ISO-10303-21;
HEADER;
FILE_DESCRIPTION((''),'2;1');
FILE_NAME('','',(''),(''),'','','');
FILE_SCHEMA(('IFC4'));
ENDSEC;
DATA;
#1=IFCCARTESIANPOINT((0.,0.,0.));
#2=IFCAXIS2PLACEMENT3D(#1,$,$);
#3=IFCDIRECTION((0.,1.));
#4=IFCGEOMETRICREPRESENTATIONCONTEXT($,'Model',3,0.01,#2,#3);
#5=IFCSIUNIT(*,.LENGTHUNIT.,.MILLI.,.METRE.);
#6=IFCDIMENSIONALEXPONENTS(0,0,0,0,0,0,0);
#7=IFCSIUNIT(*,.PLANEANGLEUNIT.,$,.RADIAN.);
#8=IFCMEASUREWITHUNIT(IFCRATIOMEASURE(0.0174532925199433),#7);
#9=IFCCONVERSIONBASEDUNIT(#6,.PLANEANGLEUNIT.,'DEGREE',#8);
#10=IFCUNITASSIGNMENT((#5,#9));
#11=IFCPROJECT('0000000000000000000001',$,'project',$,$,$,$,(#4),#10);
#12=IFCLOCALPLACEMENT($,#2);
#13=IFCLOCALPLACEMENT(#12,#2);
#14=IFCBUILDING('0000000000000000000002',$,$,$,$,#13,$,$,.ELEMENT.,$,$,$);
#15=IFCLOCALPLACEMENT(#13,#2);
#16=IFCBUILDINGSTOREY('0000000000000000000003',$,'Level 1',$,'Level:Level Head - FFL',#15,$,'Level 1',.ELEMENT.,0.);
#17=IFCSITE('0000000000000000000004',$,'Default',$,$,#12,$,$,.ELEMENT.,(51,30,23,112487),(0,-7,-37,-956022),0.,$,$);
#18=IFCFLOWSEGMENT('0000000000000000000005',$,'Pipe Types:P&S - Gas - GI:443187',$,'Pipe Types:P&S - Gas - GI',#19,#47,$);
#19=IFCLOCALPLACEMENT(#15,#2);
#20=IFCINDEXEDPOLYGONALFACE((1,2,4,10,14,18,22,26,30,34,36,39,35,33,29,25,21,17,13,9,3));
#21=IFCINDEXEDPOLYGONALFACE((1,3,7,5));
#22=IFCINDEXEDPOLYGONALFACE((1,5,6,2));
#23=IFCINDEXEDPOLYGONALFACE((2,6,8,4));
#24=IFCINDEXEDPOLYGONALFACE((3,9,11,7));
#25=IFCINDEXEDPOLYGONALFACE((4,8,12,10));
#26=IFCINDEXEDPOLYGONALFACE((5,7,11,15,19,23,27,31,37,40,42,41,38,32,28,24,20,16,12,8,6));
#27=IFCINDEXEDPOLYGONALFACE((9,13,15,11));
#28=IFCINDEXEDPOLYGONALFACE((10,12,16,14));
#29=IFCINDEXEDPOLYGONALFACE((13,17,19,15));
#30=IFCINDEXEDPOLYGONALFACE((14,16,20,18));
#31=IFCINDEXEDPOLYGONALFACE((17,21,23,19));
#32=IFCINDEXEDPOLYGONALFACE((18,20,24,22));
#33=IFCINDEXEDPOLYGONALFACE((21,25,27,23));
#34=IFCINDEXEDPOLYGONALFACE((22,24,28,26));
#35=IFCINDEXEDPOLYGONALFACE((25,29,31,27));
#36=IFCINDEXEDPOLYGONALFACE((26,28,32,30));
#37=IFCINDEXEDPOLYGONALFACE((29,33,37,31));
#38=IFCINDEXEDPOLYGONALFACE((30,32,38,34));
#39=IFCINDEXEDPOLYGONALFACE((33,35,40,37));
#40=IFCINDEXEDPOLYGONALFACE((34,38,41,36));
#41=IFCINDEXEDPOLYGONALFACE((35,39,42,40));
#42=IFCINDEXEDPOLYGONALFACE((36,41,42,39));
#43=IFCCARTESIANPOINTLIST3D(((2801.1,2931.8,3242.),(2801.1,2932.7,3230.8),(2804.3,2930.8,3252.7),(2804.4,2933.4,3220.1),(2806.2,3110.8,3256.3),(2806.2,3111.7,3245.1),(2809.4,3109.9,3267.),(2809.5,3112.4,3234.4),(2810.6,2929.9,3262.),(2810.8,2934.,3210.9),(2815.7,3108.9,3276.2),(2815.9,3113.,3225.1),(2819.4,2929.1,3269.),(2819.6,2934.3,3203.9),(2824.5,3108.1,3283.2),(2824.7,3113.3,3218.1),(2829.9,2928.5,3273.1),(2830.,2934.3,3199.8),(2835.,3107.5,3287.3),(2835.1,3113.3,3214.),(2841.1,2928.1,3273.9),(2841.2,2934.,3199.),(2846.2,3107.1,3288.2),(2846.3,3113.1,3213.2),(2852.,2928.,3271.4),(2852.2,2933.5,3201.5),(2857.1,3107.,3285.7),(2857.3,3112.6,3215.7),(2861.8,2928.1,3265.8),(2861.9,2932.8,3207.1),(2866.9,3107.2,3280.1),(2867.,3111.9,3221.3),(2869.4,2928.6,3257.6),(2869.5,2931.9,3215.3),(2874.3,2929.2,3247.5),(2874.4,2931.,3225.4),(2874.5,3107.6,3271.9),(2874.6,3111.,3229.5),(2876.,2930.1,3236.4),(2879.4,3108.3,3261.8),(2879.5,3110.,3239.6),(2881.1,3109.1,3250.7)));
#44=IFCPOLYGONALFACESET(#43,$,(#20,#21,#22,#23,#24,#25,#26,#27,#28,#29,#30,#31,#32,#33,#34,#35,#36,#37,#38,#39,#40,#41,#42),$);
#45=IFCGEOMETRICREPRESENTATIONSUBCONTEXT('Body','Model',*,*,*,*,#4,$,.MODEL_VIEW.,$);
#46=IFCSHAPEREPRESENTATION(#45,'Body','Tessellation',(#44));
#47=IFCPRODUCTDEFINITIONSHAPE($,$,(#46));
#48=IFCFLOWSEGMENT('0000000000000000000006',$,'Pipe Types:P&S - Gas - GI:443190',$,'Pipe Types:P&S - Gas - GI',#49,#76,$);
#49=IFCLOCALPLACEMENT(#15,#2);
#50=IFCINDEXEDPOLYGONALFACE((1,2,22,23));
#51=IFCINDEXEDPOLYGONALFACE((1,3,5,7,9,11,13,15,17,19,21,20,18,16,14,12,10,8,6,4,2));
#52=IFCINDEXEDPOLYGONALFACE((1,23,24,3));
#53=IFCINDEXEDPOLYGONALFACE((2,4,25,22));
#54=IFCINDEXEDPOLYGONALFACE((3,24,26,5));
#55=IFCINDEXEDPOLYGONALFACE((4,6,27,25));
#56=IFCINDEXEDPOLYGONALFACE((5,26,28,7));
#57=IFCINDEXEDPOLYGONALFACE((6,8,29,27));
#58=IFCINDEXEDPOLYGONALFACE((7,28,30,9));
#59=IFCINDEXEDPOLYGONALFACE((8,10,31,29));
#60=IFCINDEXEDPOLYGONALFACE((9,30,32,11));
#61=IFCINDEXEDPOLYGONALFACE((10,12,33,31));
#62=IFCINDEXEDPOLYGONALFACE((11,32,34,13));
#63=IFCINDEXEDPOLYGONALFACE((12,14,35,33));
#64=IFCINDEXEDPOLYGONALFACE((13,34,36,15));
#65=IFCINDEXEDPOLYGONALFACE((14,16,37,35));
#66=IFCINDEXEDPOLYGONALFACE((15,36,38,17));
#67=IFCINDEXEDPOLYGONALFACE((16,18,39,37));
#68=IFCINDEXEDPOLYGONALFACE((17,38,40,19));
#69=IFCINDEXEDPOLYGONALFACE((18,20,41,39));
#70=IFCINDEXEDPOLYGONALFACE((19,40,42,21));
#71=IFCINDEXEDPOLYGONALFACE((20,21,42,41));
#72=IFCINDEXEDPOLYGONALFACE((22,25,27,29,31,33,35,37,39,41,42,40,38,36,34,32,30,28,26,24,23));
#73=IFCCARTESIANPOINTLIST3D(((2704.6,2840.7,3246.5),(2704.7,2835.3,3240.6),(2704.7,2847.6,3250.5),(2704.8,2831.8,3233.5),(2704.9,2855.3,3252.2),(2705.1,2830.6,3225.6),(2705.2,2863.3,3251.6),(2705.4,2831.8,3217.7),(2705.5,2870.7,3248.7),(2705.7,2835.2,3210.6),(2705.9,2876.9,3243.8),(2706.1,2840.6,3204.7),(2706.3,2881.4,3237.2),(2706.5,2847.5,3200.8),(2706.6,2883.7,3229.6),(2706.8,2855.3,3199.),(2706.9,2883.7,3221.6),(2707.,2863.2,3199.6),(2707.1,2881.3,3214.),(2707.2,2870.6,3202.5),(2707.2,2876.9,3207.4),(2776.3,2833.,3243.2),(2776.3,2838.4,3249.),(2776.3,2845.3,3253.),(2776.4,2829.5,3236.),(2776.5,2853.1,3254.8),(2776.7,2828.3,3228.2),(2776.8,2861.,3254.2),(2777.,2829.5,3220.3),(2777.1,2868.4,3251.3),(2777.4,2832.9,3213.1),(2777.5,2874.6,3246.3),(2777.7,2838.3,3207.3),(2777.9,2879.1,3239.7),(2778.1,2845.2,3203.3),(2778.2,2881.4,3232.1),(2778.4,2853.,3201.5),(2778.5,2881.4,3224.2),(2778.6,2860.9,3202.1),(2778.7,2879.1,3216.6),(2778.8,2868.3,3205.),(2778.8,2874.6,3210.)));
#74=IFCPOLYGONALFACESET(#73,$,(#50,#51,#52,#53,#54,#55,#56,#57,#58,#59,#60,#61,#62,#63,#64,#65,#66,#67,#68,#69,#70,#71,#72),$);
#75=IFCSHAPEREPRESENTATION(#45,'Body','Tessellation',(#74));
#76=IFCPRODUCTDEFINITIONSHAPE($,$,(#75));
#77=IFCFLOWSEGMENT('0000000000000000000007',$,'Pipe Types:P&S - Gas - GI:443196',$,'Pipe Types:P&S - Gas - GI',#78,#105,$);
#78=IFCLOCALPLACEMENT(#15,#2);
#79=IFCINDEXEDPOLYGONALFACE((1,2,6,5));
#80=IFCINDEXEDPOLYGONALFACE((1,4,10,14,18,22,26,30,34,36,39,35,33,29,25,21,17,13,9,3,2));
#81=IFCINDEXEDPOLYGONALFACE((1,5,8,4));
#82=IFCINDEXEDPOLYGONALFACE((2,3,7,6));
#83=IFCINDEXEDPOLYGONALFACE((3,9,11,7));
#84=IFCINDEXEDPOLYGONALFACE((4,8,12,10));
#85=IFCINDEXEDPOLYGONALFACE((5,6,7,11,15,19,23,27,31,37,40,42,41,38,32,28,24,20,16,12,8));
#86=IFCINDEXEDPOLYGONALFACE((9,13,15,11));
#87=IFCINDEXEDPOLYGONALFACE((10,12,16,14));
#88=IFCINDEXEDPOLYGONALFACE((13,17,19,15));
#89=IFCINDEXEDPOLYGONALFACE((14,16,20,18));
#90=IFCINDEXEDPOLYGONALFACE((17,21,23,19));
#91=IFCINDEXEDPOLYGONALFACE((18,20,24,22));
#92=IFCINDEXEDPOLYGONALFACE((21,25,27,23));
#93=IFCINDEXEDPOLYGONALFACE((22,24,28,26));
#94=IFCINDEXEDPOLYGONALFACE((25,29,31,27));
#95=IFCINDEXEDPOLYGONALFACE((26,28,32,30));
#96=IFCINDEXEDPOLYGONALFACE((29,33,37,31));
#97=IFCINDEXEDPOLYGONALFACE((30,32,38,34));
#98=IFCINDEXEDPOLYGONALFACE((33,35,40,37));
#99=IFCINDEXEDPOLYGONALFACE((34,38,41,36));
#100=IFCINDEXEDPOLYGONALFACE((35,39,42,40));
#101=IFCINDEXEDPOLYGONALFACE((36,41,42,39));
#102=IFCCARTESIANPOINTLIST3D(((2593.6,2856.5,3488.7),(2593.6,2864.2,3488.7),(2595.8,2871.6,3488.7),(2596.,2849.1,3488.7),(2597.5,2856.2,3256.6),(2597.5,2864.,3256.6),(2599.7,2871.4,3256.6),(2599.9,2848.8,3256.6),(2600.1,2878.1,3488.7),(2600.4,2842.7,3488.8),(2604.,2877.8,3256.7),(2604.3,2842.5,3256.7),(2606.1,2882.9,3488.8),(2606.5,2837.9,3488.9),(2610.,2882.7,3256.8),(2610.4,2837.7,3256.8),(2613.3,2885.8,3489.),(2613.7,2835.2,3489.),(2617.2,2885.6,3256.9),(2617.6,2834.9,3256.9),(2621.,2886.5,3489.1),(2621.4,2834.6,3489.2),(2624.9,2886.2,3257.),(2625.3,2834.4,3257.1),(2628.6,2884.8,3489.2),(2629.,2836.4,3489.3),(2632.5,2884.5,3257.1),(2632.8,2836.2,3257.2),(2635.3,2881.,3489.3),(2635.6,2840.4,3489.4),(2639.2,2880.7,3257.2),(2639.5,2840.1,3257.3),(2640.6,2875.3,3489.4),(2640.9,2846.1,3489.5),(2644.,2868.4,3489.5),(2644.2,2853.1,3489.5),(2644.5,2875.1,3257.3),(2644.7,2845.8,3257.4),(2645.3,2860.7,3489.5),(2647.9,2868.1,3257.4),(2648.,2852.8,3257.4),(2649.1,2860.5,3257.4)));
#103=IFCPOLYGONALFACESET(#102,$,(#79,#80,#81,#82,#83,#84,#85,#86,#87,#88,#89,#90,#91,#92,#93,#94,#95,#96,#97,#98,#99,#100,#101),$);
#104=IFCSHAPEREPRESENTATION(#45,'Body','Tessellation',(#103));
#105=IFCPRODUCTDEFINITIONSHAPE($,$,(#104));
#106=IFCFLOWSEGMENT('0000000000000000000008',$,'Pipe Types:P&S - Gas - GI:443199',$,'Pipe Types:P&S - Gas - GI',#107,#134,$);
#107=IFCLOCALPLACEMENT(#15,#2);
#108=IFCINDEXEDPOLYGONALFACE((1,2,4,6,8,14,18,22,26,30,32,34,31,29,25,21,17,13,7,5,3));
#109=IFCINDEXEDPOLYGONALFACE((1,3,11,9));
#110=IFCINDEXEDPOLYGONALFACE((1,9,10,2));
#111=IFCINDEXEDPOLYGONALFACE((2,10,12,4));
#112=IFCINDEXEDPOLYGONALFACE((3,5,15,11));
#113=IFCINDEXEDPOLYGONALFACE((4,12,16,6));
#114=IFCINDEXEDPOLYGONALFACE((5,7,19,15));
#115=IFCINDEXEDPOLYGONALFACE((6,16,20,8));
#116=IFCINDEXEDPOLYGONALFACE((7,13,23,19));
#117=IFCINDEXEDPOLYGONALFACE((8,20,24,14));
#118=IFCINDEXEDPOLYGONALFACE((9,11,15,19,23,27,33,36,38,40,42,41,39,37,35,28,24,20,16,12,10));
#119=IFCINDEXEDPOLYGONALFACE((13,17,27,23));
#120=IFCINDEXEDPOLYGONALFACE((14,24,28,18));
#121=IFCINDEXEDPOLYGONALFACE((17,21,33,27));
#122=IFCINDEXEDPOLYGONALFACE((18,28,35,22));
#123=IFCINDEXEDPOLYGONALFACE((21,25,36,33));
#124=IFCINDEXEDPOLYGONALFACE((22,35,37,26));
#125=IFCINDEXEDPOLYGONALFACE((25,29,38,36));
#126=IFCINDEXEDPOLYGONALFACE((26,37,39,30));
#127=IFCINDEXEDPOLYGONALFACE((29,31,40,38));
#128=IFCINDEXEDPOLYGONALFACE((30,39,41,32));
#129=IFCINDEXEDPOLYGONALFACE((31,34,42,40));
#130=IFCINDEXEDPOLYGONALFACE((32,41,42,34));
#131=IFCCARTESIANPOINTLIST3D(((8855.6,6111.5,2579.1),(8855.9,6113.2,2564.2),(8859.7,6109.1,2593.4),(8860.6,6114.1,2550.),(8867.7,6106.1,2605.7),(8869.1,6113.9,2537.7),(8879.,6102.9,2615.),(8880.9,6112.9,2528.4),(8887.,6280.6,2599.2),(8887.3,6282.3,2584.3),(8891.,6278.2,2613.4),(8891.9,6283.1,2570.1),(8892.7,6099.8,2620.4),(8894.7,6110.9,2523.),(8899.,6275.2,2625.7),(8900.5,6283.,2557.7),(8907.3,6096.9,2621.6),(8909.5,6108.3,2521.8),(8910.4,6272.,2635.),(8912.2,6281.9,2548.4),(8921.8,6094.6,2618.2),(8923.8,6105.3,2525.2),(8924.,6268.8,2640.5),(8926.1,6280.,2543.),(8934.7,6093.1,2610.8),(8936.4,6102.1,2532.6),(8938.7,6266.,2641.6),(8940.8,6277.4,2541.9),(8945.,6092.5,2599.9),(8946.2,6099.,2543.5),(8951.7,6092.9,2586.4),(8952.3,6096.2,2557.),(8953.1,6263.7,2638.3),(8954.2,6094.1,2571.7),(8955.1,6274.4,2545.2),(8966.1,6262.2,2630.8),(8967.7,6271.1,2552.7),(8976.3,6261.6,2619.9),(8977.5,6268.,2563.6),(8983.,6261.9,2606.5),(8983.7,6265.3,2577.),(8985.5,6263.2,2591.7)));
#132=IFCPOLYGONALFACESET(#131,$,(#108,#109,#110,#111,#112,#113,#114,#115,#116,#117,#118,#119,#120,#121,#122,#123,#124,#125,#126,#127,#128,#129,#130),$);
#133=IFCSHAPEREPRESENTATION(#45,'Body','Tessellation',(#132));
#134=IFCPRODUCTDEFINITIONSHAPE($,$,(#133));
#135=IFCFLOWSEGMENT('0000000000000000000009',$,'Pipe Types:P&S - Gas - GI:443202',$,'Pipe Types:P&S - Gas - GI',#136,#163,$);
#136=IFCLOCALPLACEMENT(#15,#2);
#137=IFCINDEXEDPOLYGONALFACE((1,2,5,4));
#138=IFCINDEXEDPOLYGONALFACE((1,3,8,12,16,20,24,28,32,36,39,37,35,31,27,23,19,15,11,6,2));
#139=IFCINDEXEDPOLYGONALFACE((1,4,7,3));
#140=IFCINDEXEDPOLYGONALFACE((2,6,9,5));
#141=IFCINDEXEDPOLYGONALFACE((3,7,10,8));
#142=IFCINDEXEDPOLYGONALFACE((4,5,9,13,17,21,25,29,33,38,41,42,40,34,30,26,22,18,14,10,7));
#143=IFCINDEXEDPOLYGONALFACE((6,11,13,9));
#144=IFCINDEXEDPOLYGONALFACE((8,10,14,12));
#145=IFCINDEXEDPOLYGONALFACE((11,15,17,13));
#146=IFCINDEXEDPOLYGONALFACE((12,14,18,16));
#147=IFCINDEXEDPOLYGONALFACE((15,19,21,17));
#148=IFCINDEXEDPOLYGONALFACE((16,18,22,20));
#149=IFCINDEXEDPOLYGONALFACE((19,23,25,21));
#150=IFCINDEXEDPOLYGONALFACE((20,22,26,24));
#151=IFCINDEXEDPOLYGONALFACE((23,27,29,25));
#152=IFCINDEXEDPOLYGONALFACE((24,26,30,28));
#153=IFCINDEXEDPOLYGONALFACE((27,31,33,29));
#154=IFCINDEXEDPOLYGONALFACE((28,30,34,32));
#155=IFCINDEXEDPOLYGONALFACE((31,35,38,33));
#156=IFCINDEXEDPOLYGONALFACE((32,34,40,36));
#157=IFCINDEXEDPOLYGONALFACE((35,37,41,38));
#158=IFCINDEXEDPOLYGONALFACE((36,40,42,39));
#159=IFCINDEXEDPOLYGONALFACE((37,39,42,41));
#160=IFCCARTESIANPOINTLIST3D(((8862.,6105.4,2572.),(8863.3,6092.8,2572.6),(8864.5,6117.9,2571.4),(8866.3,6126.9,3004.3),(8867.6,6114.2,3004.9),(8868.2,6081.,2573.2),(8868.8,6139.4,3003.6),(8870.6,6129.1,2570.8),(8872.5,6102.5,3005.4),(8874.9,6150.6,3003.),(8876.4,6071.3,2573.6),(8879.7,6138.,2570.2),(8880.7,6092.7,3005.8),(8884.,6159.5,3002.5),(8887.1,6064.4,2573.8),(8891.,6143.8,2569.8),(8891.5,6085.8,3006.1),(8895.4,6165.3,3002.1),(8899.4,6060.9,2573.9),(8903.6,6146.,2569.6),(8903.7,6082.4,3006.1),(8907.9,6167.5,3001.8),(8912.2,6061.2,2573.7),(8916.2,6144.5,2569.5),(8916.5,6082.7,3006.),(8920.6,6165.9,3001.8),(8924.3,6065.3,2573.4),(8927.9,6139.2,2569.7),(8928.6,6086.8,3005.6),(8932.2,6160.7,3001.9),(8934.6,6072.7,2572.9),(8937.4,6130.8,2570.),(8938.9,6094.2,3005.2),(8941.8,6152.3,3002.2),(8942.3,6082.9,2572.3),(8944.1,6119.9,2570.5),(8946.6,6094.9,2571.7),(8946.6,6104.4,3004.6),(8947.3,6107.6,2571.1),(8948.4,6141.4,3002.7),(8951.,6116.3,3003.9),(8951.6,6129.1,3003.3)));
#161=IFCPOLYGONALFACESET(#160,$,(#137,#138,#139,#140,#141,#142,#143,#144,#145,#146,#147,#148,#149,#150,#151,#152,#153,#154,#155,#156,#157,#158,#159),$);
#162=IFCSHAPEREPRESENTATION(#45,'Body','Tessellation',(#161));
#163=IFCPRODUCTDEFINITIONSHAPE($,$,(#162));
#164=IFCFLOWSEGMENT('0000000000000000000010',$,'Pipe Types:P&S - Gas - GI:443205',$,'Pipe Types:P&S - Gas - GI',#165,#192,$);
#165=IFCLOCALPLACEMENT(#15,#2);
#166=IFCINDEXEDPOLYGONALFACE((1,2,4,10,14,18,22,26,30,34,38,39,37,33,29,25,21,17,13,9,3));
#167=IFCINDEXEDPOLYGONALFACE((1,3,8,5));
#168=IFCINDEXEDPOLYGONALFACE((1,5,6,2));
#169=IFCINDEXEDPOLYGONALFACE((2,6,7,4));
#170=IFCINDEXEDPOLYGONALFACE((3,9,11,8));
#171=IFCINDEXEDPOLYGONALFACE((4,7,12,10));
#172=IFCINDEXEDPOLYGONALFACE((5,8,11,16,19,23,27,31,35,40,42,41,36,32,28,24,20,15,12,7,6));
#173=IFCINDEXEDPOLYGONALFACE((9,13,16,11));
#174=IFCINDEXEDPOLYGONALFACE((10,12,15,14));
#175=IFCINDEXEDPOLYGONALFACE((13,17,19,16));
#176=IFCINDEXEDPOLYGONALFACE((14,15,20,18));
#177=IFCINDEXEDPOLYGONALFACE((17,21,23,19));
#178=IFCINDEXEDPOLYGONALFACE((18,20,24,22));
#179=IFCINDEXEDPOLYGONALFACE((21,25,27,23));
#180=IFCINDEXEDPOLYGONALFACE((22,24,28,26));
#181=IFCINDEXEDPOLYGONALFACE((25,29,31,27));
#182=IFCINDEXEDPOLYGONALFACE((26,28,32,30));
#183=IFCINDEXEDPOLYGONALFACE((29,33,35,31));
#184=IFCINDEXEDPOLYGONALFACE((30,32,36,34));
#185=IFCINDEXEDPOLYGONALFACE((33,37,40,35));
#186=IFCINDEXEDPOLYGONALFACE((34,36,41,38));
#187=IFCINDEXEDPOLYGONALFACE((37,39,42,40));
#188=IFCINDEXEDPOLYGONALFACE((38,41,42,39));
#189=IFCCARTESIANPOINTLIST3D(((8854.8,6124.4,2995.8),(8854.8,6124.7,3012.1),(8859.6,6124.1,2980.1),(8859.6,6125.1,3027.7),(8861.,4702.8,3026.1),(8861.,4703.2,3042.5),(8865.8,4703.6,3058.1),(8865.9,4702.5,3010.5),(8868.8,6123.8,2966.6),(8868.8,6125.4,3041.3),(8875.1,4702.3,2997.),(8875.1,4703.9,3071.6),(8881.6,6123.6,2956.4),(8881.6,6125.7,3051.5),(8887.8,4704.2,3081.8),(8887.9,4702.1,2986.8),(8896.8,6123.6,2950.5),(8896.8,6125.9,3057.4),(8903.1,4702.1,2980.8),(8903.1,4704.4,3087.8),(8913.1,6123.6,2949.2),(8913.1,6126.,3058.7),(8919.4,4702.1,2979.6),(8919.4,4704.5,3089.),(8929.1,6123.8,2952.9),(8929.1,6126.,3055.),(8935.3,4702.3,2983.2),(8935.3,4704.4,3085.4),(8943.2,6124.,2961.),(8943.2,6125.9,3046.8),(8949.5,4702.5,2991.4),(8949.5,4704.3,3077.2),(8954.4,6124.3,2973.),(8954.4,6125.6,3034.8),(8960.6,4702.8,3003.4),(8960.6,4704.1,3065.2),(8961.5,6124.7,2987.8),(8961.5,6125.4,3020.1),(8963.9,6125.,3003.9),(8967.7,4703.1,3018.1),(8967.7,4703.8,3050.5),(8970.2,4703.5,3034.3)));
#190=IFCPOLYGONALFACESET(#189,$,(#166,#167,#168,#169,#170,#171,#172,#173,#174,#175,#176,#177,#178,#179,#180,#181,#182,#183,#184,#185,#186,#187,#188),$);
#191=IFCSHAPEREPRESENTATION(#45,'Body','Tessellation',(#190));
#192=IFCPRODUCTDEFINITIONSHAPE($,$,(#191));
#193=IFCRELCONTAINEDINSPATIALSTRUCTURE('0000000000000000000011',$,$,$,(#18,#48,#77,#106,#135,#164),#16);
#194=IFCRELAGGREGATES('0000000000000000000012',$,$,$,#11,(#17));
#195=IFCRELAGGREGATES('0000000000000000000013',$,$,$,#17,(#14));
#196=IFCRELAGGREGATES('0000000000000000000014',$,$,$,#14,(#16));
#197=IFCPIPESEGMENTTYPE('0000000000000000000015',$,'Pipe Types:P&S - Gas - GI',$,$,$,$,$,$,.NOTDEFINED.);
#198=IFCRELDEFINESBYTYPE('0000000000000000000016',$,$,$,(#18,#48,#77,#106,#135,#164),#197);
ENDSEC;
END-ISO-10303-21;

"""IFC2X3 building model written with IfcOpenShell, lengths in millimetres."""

from ifc_helpers import new_model, entity, si_unit, converted_unit, direction, frame, frame_2d, origin, origin_2d_with_axis, place, context, subcontext, project, spatial, circle, extrude, type_object, element, save


model = new_model("IFC2X3")

# Units and contexts
model_context = context("Model", 3, precision=0.01, world=origin(), true_north=direction((0.0, 1.0)))
body_context = subcontext(model_context, "Body", "Model", "MODEL_VIEW")
ifc_project = project(units=[si_unit("LENGTHUNIT", "METRE", prefix="MILLI"), converted_unit("PLANEANGLEUNIT", "DEGREE", entity("IfcRatioMeasure", 0.0174532925199433), si_unit("PLANEANGLEUNIT", "RADIAN"), dimensions=[0, 0, 0, 0, 0, 0, 0])], contexts=[model_context])

# Site, building, storey
site_placement = place(None, origin())
site = spatial("IfcSite", under=ifc_project, at=site_placement, Name="Default", CompositionType="ELEMENT", RefLatitude=(51, 30, 23, 112487), RefLongitude=(0, -7, -37, -956022), RefElevation=0.0)
building_placement = place(site_placement, origin())
building = spatial("IfcBuilding", under=site, at=building_placement, CompositionType="ELEMENT")
storey_placement = place(building_placement, origin())
storey = spatial("IfcBuildingStorey", under=building, at=storey_placement, Name="Level 1", ObjectType="Level:Level Head - FFL", LongName="Level 1", CompositionType="ELEMENT", Elevation=0.0)

# Flow segments
pipe_segment_type = type_object("IfcPipeSegmentType", Name="Pipe Types:P&S - Gas - GI", PredefinedType="NOTDEFINED")
flow_segment_1_placement = place(storey_placement, origin())
element("IfcFlowSegment", 1, at=flow_segment_1_placement, inside=storey, type_object=pipe_segment_type, Name="Pipe Types:P&S - Gas - GI:443187", ObjectType="Pipe Types:P&S - Gas - GI", context=body_context, shape_type="SweptSolid", body=[
    extrude(circle(Radius=37.7, at=frame_2d((0.0, 0.0), x_axis=(1.0, 0.0))), frame((2838.3, 2931.1, 3236.4), z_axis=(0.028365, 0.996451, 0.079247), x_axis=(0.999595, -0.028455, 0.0)), (0.0, 0.0, 1.0), 179.7),
])
flow_segment_2_placement = place(storey_placement, origin())
element("IfcFlowSegment", 2, at=flow_segment_2_placement, inside=storey, type_object=pipe_segment_type, Name="Pipe Types:P&S - Gas - GI:443190", ObjectType="Pipe Types:P&S - Gas - GI", context=body_context, shape_type="SweptSolid", body=[
    extrude(circle(Radius=26.7, at=frame_2d((0.0, 0.0), x_axis=(1.0, 0.0))), frame((2705.9, 2857.3, 3225.6), z_axis=(0.998858, -0.03192, 0.035552), x_axis=(-0.03194, -0.99949, 0.0)), (0.0, 0.0, 1.0), 71.7),
])
flow_segment_3_placement = place(storey_placement, origin())
element("IfcFlowSegment", 3, at=flow_segment_3_placement, inside=storey, type_object=pipe_segment_type, Name="Pipe Types:P&S - Gas - GI:443196", ObjectType="Pipe Types:P&S - Gas - GI", context=body_context, shape_type="SweptSolid", body=[
    extrude(circle(Radius=26.0, at=frame_2d((0.0, 0.0), x_axis=(1.0, 0.0))), frame((2623.2, 2860.3, 3257.0), z_axis=(-0.016734, 0.001125, 0.999859), x_axis=(0.067081, 0.997748, 0.0)), (0.0, 0.0, 1.0), 232.1),
])
flow_segment_4_placement = place(storey_placement, origin())
element("IfcFlowSegment", 4, at=flow_segment_4_placement, inside=storey, type_object=pipe_segment_type, Name="Pipe Types:P&S - Gas - GI:443199", ObjectType="Pipe Types:P&S - Gas - GI", context=body_context, shape_type="SweptSolid", body=[
    extrude(circle(Radius=50.3, at=origin_2d_with_axis()), frame((8904.7, 6103.3, 2571.7), z_axis=(0.181085, 0.976626, 0.115802), x_axis=(0.983241, -0.182311, 0.0)), (0.0, 0.0, 1.0), 173.1),
])
flow_segment_5_placement = place(storey_placement, origin())
element("IfcFlowSegment", 5, at=flow_segment_5_placement, inside=storey, type_object=pipe_segment_type, Name="Pipe Types:P&S - Gas - GI:443202", ObjectType="Pipe Types:P&S - Gas - GI", context=body_context, shape_type="SweptSolid", body=[
    extrude(circle(Radius=42.8, at=origin_2d_with_axis()), frame((8904.7, 6103.3, 2571.7), z_axis=(0.009986, 0.049592, 0.99872), x_axis=(0.980323, -0.197401, 0.0)), (0.0, 0.0, 1.0), 432.8),
])
flow_segment_6_placement = place(storey_placement, origin())
element("IfcFlowSegment", 6, at=flow_segment_6_placement, inside=storey, type_object=pipe_segment_type, Name="Pipe Types:P&S - Gas - GI:443205", ObjectType="Pipe Types:P&S - Gas - GI", context=body_context, shape_type="SweptSolid", body=[
    extrude(circle(Radius=54.9, at=frame_2d((0.0, 0.0), x_axis=(1.0, 0.0))), frame((8915.3, 4703.3, 3034.3), z_axis=(-0.004408, 0.999762, -0.021364), x_axis=(0.99999, 0.004409, 0.0)), (0.0, 0.0, 1.0), 1421.9),
])

save(model, "model.ifc")
